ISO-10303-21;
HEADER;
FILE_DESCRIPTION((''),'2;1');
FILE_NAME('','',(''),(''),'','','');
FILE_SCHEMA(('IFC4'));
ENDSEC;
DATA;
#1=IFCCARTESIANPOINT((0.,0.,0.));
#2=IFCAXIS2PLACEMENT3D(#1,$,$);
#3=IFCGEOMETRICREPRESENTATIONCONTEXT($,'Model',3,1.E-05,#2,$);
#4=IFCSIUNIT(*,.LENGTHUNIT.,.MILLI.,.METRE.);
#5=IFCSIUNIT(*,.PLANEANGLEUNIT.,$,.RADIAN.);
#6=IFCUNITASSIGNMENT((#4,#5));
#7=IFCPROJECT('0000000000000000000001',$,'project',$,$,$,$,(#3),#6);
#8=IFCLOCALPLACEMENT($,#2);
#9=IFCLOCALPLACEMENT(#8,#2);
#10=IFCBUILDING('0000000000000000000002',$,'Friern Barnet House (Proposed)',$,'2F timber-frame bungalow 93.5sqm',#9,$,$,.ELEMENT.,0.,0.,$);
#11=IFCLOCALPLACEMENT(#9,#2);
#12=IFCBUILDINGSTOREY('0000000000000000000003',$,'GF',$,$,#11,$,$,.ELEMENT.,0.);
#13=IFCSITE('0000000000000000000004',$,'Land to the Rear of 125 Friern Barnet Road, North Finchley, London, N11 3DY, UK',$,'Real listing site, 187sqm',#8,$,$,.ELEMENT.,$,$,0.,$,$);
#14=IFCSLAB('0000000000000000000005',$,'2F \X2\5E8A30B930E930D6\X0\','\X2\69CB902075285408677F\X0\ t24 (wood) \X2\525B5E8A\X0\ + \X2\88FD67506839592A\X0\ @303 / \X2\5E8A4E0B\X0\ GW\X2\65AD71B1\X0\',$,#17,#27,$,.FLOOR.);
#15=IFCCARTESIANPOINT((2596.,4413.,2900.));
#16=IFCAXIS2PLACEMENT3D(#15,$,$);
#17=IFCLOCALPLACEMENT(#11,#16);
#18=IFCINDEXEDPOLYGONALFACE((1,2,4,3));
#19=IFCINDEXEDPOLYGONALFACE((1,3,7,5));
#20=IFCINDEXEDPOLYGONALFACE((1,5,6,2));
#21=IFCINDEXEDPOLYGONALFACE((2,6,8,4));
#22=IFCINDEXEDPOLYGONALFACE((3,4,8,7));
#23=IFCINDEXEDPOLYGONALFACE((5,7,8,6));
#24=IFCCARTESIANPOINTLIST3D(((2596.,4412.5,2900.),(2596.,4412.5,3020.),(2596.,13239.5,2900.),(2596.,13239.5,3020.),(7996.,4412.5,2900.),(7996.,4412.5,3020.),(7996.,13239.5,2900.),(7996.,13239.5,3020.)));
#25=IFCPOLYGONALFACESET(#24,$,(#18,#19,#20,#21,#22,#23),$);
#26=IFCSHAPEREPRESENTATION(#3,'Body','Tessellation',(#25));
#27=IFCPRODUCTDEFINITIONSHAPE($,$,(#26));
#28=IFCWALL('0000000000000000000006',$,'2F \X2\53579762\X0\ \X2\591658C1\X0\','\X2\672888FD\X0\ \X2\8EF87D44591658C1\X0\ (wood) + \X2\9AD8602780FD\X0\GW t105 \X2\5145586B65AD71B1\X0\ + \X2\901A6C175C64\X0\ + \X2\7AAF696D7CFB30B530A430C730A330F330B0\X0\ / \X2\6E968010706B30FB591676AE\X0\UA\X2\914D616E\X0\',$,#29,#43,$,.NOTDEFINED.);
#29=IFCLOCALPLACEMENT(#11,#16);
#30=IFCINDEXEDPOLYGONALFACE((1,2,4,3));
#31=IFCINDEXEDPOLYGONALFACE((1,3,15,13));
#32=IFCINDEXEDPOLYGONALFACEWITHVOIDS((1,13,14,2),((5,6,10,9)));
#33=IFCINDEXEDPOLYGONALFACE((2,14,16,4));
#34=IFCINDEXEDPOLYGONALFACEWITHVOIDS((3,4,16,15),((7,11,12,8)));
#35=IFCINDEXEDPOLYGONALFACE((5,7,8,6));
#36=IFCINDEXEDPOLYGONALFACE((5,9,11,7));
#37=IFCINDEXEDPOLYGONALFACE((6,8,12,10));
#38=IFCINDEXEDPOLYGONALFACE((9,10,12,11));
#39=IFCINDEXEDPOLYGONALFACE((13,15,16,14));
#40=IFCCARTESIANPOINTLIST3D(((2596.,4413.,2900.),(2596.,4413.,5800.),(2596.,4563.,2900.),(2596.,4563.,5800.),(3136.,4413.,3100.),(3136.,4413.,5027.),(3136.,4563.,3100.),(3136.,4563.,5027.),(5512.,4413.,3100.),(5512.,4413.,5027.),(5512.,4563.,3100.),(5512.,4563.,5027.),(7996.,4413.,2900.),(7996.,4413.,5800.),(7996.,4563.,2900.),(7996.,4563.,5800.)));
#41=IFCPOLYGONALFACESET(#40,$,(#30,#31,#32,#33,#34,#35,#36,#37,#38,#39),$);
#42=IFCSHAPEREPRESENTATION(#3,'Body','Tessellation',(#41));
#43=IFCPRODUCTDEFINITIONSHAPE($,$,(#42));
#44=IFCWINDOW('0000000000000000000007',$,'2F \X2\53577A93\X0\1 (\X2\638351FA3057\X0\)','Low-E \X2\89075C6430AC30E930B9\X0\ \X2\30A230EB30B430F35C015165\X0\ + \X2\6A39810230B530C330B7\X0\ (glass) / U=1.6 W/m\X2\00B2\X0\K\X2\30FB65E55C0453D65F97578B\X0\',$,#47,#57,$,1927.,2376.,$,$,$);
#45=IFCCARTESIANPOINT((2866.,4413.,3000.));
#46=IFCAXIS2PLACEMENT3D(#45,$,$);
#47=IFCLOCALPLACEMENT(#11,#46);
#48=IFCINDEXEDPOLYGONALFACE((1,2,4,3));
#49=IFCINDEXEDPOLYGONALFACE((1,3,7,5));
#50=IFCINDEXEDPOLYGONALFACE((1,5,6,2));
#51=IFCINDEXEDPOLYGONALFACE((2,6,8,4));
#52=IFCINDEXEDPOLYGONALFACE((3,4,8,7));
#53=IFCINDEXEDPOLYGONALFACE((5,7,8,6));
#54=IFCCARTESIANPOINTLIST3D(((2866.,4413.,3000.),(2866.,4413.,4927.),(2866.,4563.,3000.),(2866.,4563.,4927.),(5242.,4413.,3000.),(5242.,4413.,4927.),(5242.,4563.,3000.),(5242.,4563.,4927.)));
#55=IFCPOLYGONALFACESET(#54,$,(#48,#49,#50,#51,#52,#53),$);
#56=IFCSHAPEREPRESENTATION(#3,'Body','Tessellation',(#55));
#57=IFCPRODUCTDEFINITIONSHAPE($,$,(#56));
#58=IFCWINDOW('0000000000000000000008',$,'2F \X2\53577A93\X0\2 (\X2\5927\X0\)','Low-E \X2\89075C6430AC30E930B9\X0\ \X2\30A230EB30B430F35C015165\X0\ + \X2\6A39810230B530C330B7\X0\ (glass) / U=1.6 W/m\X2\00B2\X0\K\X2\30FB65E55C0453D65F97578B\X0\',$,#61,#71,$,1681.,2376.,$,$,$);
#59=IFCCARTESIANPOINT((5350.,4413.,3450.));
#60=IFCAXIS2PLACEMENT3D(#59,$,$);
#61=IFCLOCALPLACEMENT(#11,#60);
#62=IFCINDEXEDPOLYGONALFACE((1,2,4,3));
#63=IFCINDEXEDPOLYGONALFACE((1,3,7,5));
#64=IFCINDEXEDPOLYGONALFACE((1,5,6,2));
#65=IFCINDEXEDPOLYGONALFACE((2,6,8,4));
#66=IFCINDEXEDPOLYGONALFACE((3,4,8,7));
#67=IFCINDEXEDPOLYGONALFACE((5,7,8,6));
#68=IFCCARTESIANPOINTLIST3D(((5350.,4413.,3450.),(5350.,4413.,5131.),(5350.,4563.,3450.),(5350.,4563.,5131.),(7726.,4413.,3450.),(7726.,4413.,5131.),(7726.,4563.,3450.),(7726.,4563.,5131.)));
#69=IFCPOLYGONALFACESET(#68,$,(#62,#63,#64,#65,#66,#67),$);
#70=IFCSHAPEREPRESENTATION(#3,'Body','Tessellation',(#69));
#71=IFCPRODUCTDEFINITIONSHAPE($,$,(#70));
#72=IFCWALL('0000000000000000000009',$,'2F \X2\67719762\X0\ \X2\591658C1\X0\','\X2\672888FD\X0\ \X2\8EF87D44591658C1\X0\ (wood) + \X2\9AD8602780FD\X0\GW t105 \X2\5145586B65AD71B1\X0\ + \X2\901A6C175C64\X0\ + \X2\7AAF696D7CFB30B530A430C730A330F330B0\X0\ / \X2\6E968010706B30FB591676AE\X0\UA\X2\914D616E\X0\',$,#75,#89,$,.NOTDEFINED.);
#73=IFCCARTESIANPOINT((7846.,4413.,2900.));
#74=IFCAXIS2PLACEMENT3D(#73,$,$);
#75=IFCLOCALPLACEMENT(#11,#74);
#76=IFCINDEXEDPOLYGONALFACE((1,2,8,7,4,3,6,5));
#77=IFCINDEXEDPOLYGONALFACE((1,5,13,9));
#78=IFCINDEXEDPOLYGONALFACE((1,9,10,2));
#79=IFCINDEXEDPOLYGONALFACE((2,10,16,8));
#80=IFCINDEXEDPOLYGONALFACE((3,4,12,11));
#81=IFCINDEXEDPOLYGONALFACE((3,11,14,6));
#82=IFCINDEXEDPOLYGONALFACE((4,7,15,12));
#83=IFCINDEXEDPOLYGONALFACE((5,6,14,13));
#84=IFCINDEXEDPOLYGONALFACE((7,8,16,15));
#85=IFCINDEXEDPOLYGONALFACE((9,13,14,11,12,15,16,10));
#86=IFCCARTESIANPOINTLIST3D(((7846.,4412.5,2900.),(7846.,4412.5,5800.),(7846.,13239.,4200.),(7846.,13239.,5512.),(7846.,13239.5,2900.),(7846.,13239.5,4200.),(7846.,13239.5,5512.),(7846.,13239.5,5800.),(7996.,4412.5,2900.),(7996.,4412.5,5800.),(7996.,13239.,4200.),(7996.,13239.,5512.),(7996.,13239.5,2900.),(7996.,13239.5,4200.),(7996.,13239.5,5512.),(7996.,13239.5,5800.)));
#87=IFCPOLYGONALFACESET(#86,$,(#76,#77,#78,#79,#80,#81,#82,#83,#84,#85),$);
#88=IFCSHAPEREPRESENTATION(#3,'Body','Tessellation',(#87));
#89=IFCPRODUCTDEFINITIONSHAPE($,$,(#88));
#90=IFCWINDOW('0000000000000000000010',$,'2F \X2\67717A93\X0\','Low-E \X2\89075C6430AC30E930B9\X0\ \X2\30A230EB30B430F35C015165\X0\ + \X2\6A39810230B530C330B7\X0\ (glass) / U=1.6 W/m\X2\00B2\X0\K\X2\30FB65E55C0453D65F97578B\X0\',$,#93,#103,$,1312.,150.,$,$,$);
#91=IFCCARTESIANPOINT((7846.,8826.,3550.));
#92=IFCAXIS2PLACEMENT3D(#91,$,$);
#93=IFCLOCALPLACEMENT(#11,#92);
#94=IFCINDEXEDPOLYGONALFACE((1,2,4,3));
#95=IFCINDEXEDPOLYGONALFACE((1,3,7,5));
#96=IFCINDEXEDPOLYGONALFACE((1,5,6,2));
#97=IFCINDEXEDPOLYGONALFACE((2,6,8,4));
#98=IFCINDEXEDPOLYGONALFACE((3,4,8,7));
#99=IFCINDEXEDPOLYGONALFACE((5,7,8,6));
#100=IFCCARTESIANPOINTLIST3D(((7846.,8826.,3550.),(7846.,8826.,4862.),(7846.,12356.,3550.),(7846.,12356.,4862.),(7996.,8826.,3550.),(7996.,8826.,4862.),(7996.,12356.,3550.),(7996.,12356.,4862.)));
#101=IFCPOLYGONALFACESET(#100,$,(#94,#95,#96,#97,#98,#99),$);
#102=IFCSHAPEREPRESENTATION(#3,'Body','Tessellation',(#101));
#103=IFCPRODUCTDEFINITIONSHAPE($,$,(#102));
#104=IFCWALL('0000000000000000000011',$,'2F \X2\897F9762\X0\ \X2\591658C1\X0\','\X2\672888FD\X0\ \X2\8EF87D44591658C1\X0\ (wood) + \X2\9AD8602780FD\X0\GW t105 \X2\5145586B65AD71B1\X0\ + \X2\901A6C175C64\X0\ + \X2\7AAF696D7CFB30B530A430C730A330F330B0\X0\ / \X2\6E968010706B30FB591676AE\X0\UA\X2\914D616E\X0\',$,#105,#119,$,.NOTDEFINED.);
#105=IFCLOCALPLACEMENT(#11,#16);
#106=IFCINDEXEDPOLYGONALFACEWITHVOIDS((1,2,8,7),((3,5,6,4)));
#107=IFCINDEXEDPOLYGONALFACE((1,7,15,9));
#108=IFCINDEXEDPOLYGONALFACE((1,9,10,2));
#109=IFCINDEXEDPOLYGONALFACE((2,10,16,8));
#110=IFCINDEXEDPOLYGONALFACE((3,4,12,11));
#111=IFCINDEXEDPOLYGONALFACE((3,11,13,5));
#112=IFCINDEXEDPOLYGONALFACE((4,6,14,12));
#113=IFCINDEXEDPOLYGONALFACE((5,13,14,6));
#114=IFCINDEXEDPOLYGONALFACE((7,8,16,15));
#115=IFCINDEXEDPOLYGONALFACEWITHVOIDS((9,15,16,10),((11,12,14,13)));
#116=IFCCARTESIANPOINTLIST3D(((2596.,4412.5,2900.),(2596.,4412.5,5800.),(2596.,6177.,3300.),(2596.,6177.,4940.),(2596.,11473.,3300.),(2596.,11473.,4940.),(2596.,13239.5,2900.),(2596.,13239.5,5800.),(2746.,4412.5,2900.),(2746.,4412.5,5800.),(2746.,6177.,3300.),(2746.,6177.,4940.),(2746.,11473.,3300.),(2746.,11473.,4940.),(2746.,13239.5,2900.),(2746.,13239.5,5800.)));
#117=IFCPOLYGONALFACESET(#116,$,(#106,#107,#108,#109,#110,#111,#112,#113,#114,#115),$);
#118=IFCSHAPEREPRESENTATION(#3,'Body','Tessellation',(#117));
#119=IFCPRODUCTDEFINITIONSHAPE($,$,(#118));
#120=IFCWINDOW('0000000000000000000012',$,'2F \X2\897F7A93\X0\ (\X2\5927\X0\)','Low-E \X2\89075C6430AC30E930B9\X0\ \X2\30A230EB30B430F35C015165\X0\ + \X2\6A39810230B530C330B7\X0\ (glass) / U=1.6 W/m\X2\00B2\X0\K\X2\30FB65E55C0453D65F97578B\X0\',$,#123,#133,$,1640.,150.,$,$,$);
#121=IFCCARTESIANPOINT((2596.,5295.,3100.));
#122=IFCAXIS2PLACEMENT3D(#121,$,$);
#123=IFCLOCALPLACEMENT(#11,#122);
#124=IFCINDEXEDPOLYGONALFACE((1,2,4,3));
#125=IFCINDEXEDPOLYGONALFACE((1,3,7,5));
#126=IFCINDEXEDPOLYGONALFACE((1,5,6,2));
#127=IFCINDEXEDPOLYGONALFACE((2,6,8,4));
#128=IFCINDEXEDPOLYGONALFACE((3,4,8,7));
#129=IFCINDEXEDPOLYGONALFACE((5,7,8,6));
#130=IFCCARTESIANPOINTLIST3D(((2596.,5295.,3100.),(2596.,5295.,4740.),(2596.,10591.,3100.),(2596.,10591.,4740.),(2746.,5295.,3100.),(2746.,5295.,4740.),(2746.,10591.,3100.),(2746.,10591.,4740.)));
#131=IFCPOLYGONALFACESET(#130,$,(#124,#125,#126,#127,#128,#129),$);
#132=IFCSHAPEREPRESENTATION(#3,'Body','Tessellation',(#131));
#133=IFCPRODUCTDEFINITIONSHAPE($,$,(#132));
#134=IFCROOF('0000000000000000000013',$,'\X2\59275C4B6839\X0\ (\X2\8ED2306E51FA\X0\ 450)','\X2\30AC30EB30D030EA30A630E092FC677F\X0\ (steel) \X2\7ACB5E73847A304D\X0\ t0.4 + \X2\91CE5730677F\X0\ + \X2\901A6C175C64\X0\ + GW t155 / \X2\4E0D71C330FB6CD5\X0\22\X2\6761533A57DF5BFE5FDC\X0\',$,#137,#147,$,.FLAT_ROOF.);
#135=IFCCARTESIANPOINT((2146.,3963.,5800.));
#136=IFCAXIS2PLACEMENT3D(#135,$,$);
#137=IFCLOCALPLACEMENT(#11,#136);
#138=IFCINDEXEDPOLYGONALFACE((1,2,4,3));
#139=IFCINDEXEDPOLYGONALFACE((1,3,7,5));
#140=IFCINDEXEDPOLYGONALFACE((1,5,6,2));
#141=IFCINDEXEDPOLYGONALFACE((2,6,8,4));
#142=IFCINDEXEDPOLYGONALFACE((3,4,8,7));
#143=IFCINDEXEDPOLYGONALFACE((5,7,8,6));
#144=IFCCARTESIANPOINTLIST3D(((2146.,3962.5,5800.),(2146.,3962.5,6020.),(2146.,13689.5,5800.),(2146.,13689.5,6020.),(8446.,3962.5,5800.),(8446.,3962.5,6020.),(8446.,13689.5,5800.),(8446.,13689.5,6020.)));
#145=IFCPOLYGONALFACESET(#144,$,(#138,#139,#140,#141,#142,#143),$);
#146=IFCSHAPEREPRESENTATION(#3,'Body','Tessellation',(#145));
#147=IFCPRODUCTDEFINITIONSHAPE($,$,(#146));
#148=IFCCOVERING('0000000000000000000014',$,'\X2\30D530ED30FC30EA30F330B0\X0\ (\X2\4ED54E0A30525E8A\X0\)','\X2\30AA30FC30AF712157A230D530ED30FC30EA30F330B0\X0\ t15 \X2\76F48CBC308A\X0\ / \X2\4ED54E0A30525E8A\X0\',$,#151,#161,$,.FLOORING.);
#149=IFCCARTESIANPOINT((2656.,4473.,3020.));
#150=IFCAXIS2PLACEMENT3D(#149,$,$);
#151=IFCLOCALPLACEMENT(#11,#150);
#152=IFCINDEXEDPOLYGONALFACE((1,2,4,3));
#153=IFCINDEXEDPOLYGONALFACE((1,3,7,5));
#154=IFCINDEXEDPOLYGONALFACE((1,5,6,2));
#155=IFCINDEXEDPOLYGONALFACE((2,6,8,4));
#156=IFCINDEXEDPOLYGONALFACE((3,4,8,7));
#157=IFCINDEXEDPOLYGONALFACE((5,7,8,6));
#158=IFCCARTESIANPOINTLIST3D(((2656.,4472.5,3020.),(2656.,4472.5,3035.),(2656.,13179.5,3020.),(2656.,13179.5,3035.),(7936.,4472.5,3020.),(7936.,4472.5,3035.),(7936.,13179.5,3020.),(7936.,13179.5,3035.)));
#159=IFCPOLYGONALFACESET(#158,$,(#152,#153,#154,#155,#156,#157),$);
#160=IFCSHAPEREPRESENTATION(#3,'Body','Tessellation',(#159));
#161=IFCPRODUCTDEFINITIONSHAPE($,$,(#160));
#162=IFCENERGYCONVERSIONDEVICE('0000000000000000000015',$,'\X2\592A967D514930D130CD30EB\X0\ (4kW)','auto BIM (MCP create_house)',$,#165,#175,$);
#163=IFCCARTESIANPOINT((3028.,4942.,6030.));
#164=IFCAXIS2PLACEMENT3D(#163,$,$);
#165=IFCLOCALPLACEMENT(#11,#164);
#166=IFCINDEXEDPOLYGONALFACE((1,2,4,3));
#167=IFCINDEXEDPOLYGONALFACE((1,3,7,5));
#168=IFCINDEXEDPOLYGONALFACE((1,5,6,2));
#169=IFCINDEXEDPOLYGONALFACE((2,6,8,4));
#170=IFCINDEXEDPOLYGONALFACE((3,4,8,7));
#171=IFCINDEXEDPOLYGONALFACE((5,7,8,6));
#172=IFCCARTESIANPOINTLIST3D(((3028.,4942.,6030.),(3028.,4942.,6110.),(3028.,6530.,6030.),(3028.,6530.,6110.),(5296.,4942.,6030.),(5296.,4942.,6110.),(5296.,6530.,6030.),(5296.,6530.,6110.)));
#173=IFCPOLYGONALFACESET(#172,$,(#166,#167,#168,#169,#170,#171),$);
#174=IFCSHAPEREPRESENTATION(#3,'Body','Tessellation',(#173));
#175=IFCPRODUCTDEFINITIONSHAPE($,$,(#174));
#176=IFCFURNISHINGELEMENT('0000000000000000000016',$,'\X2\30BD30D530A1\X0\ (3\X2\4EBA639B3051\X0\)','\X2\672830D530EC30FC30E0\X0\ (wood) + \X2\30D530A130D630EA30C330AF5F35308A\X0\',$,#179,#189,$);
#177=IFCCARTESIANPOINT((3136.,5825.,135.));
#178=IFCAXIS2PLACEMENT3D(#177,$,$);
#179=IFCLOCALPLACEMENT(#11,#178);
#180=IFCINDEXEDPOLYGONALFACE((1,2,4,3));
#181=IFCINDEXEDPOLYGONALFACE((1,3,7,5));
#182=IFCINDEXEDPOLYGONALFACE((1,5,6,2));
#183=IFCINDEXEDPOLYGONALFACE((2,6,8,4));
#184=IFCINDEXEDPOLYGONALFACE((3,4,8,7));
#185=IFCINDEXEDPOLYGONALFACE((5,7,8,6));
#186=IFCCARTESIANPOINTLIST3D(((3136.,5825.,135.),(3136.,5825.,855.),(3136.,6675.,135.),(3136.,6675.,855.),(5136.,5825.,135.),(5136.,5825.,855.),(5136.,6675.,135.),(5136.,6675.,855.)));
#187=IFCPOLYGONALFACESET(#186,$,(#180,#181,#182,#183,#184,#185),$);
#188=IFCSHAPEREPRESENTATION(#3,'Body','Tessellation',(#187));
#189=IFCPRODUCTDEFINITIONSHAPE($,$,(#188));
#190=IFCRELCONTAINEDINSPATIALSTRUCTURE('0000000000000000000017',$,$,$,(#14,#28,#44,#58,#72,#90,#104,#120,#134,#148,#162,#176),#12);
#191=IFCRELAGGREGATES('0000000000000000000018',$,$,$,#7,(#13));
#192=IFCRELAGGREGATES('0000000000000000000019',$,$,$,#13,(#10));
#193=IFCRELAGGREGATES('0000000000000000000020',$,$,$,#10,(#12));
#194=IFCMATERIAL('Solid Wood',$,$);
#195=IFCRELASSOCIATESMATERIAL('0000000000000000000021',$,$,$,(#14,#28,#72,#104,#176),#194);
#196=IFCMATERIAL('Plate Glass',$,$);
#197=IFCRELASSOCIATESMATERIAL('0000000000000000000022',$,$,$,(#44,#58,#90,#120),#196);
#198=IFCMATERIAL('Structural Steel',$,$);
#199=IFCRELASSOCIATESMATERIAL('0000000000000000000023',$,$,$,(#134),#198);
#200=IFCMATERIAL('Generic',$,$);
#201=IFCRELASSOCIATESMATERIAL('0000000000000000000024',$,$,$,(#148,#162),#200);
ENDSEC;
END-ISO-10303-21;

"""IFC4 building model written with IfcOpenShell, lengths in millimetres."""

from ifc_helpers import new_model, si_unit, frame, frame_2d, origin, place, context, project, spatial, rectangle, extrude, material, element, fill, save


model = new_model("IFC4")

# Units and contexts
model_context = context("Model", 3, precision=1e-05, world=origin())
ifc_project = project(units=[si_unit("LENGTHUNIT", "METRE", prefix="MILLI"), si_unit("PLANEANGLEUNIT", "RADIAN")], contexts=[model_context])

# Site, building, storey
site_placement = place(None, origin())
site = spatial("IfcSite", under=ifc_project, at=site_placement, Name="Land to the Rear of 125 Friern Barnet Road, North Finchley, London, N11 3DY, UK", ObjectType="Real listing site, 187sqm", CompositionType="ELEMENT", RefElevation=0.0)
building_placement = place(site_placement, origin())
building = spatial("IfcBuilding", under=site, at=building_placement, Name="Friern Barnet House (Proposed)", ObjectType="2F timber-frame bungalow 93.5sqm", CompositionType="ELEMENT", ElevationOfRefHeight=0.0, ElevationOfTerrain=0.0)
storey_placement = place(building_placement, origin())
storey = spatial("IfcBuildingStorey", under=building, at=storey_placement, Name="GF", CompositionType="ELEMENT", Elevation=0.0)

# Slab
ifc_material_1 = material(Name="Solid Wood")
slab_placement = place(storey_placement, frame((2596.0, 4413.0, 2900.0)))
element("IfcSlab", 1, at=slab_placement, inside=storey, material=ifc_material_1, Name="2F 床スラブ", Description="構造用合板 t24 (wood) 剛床 + 製材根太 @303 / 床下 GW断熱", PredefinedType="FLOOR", context=model_context, shape_type="SweptSolid", body=[
    extrude(rectangle(XDim=5400.0, YDim=8827.0, at=frame_2d((2700.0, 4413.0))), frame((2596.0, 4413.0, 2900.0)), (0.0, 0.0, 1.0), 120.0),
])

# Wall, openings, windows
wall_1_placement = place(storey_placement, frame((2596.0, 4413.0, 2900.0)))
wall_1 = element("IfcWall", 2, at=wall_1_placement, inside=storey, material=ifc_material_1, Name="2F 南面 外壁", Description="木製 軸組外壁 (wood) + 高性能GW t105 充填断熱 + 通気層 + 窯業系サイディング / 準耐火・外皮UA配慮", PredefinedType="NOTDEFINED", context=model_context, shape_type="SweptSolid", body=[
    extrude(rectangle(XDim=5400.0, YDim=150.0, at=frame_2d((2700.0, 75.0))), frame((2596.0, 4413.0, 2900.0)), (0.0, 0.0, 1.0), 2900.0),
])
opening_1_placement = place(storey_placement, frame((2866.0, 4413.0, 3000.0)))
opening_1 = element("IfcOpeningElement", 3, at=opening_1_placement, cuts=wall_1, PredefinedType="NOTDEFINED", context=model_context, shape_type="SweptSolid", body=[
    extrude(rectangle(XDim=2376.0, YDim=150.0, at=frame_2d((1188.0, 75.0))), frame((2866.0, 4413.0, 3000.0)), (0.0, 0.0, 1.0), 1927.0),
])
opening_2_placement = place(storey_placement, frame((5350.0, 4413.0, 3450.0)))
opening_2 = element("IfcOpeningElement", 4, at=opening_2_placement, cuts=wall_1, PredefinedType="NOTDEFINED", context=model_context, shape_type="SweptSolid", body=[
    extrude(rectangle(XDim=2376.0, YDim=150.0, at=frame_2d((1188.0, 75.0))), frame((5350.0, 4413.0, 3450.0)), (0.0, 0.0, 1.0), 1681.0),
])
ifc_material_2 = material(Name="Plate Glass")
window_1_placement = place(storey_placement, frame((2866.0, 4413.0, 3000.0)))
window_1 = element("IfcWindow", 5, at=window_1_placement, inside=storey, material=ifc_material_2, Name="2F 南窓1 (掃出し)", Description="Low-E 複層ガラス アルゴン封入 + 樹脂サッシ (glass) / U=1.6 W/m²K・日射取得型", OverallHeight=1927.0, OverallWidth=2376.0, context=model_context, shape_type="SweptSolid", body=[
    extrude(rectangle(XDim=2376.0, YDim=150.0, at=frame_2d((1188.0, 75.0))), frame((2866.0, 4413.0, 3000.0)), (0.0, 0.0, 1.0), 1927.0),
])
fill(opening_1, window_1)
window_2_placement = place(storey_placement, frame((5350.0, 4413.0, 3450.0)))
window_2 = element("IfcWindow", 6, at=window_2_placement, inside=storey, material=ifc_material_2, Name="2F 南窓2 (大)", Description="Low-E 複層ガラス アルゴン封入 + 樹脂サッシ (glass) / U=1.6 W/m²K・日射取得型", OverallHeight=1681.0, OverallWidth=2376.0, context=model_context, shape_type="SweptSolid", body=[
    extrude(rectangle(XDim=2376.0, YDim=150.0, at=frame_2d((1188.0, 75.0))), frame((5350.0, 4413.0, 3450.0)), (0.0, 0.0, 1.0), 1681.0),
])
fill(opening_2, window_2)

# Walls, openings, windows
wall_2_placement = place(storey_placement, frame((7846.0, 4413.0, 2900.0)))
wall_2 = element("IfcWall", 7, at=wall_2_placement, inside=storey, material=ifc_material_1, Name="2F 東面 外壁", Description="木製 軸組外壁 (wood) + 高性能GW t105 充填断熱 + 通気層 + 窯業系サイディング / 準耐火・外皮UA配慮", PredefinedType="NOTDEFINED", context=model_context, shape_type="SweptSolid", body=[
    extrude(rectangle(XDim=150.0, YDim=8827.0, at=frame_2d((75.0, 4413.0))), frame((7846.0, 4413.0, 2900.0)), (0.0, 0.0, 1.0), 2900.0),
])
opening_3_placement = place(storey_placement, frame((7846.0, 8826.0, 3550.0)))
opening_3 = element("IfcOpeningElement", 8, at=opening_3_placement, cuts=wall_2, PredefinedType="NOTDEFINED", context=model_context, shape_type="SweptSolid", body=[
    extrude(rectangle(XDim=150.0, YDim=3530.0, at=frame_2d((75.0, 1765.0))), frame((7846.0, 8826.0, 3550.0)), (0.0, 0.0, 1.0), 1312.0),
])
window_3_placement = place(storey_placement, frame((7846.0, 8826.0, 3550.0)))
window_3 = element("IfcWindow", 9, at=window_3_placement, inside=storey, material=ifc_material_2, Name="2F 東窓", Description="Low-E 複層ガラス アルゴン封入 + 樹脂サッシ (glass) / U=1.6 W/m²K・日射取得型", OverallHeight=1312.0, OverallWidth=150.0, context=model_context, shape_type="SweptSolid", body=[
    extrude(rectangle(XDim=150.0, YDim=3530.0, at=frame_2d((75.0, 1765.0))), frame((7846.0, 8826.0, 3550.0)), (0.0, 0.0, 1.0), 1312.0),
])
fill(opening_3, window_3)
wall_3_placement = place(storey_placement, frame((2596.0, 4413.0, 2900.0)))
wall_3 = element("IfcWall", 10, at=wall_3_placement, inside=storey, material=ifc_material_1, Name="2F 西面 外壁", Description="木製 軸組外壁 (wood) + 高性能GW t105 充填断熱 + 通気層 + 窯業系サイディング / 準耐火・外皮UA配慮", PredefinedType="NOTDEFINED", context=model_context, shape_type="SweptSolid", body=[
    extrude(rectangle(XDim=150.0, YDim=8827.0, at=frame_2d((75.0, 4413.0))), frame((2596.0, 4413.0, 2900.0)), (0.0, 0.0, 1.0), 2900.0),
])
opening_4_placement = place(storey_placement, frame((2596.0, 5295.0, 3100.0)))
opening_4 = element("IfcOpeningElement", 11, at=opening_4_placement, cuts=wall_3, PredefinedType="NOTDEFINED", context=model_context, shape_type="SweptSolid", body=[
    extrude(rectangle(XDim=150.0, YDim=5296.0, at=frame_2d((75.0, 2648.0))), frame((2596.0, 5295.0, 3100.0)), (0.0, 0.0, 1.0), 1640.0),
])
window_4_placement = place(storey_placement, frame((2596.0, 5295.0, 3100.0)))
window_4 = element("IfcWindow", 12, at=window_4_placement, inside=storey, material=ifc_material_2, Name="2F 西窓 (大)", Description="Low-E 複層ガラス アルゴン封入 + 樹脂サッシ (glass) / U=1.6 W/m²K・日射取得型", OverallHeight=1640.0, OverallWidth=150.0, context=model_context, shape_type="SweptSolid", body=[
    extrude(rectangle(XDim=150.0, YDim=5296.0, at=frame_2d((75.0, 2648.0))), frame((2596.0, 5295.0, 3100.0)), (0.0, 0.0, 1.0), 1640.0),
])
fill(opening_4, window_4)

# Roof
ifc_material_3 = material(Name="Structural Steel")
roof_placement = place(storey_placement, frame((2146.0, 3963.0, 5800.0)))
element("IfcRoof", 13, at=roof_placement, inside=storey, material=ifc_material_3, Name="大屋根 (軒の出 450)", Description="ガルバリウム鋼板 (steel) 立平葺き t0.4 + 野地板 + 通気層 + GW t155 / 不燃・法22条区域対応", PredefinedType="FLAT_ROOF", context=model_context, shape_type="SweptSolid", body=[
    extrude(rectangle(XDim=6300.0, YDim=9727.0, at=frame_2d((3150.0, 4863.0))), frame((2146.0, 3963.0, 5800.0)), (0.0, 0.0, 1.0), 220.0),
])

# Covering
ifc_material_4 = material(Name="Generic")
covering_placement = place(storey_placement, frame((2656.0, 4473.0, 3020.0)))
element("IfcCovering", 14, at=covering_placement, inside=storey, material=ifc_material_4, Name="フローリング (仕上げ床)", Description="オーク無垢フローリング t15 直貼り / 仕上げ床", PredefinedType="FLOORING", context=model_context, shape_type="SweptSolid", body=[
    extrude(rectangle(XDim=5280.0, YDim=8707.0, at=frame_2d((2640.0, 4353.0))), frame((2656.0, 4473.0, 3020.0)), (0.0, 0.0, 1.0), 15.0),
])

# Energy conversion device
energy_conversion_device_placement = place(storey_placement, frame((3028.0, 4942.0, 6030.0)))
element("IfcEnergyConversionDevice", 15, at=energy_conversion_device_placement, inside=storey, material=ifc_material_4, Name="太陽光パネル (4kW)", Description="auto BIM (MCP create_house)", context=model_context, shape_type="SweptSolid", body=[
    extrude(rectangle(XDim=2268.0, YDim=1588.0, at=frame_2d((1134.0, 794.0))), frame((3028.0, 4942.0, 6030.0)), (0.0, 0.0, 1.0), 80.0),
])

# Furnishing element
furnishing_1_placement = place(storey_placement, frame((3136.0, 5825.0, 135.0)))
element("IfcFurnishingElement", 16, at=furnishing_1_placement, inside=storey, material=ifc_material_1, Name="ソファ (3人掛け)", Description="木フレーム (wood) + ファブリック張り", context=model_context, shape_type="SweptSolid", body=[
    extrude(rectangle(XDim=2000.0, YDim=850.0, at=frame_2d((1000.0, 425.0))), frame((3136.0, 5825.0, 135.0)), (0.0, 0.0, 1.0), 720.0),
])

save(model, "model.ifc")
